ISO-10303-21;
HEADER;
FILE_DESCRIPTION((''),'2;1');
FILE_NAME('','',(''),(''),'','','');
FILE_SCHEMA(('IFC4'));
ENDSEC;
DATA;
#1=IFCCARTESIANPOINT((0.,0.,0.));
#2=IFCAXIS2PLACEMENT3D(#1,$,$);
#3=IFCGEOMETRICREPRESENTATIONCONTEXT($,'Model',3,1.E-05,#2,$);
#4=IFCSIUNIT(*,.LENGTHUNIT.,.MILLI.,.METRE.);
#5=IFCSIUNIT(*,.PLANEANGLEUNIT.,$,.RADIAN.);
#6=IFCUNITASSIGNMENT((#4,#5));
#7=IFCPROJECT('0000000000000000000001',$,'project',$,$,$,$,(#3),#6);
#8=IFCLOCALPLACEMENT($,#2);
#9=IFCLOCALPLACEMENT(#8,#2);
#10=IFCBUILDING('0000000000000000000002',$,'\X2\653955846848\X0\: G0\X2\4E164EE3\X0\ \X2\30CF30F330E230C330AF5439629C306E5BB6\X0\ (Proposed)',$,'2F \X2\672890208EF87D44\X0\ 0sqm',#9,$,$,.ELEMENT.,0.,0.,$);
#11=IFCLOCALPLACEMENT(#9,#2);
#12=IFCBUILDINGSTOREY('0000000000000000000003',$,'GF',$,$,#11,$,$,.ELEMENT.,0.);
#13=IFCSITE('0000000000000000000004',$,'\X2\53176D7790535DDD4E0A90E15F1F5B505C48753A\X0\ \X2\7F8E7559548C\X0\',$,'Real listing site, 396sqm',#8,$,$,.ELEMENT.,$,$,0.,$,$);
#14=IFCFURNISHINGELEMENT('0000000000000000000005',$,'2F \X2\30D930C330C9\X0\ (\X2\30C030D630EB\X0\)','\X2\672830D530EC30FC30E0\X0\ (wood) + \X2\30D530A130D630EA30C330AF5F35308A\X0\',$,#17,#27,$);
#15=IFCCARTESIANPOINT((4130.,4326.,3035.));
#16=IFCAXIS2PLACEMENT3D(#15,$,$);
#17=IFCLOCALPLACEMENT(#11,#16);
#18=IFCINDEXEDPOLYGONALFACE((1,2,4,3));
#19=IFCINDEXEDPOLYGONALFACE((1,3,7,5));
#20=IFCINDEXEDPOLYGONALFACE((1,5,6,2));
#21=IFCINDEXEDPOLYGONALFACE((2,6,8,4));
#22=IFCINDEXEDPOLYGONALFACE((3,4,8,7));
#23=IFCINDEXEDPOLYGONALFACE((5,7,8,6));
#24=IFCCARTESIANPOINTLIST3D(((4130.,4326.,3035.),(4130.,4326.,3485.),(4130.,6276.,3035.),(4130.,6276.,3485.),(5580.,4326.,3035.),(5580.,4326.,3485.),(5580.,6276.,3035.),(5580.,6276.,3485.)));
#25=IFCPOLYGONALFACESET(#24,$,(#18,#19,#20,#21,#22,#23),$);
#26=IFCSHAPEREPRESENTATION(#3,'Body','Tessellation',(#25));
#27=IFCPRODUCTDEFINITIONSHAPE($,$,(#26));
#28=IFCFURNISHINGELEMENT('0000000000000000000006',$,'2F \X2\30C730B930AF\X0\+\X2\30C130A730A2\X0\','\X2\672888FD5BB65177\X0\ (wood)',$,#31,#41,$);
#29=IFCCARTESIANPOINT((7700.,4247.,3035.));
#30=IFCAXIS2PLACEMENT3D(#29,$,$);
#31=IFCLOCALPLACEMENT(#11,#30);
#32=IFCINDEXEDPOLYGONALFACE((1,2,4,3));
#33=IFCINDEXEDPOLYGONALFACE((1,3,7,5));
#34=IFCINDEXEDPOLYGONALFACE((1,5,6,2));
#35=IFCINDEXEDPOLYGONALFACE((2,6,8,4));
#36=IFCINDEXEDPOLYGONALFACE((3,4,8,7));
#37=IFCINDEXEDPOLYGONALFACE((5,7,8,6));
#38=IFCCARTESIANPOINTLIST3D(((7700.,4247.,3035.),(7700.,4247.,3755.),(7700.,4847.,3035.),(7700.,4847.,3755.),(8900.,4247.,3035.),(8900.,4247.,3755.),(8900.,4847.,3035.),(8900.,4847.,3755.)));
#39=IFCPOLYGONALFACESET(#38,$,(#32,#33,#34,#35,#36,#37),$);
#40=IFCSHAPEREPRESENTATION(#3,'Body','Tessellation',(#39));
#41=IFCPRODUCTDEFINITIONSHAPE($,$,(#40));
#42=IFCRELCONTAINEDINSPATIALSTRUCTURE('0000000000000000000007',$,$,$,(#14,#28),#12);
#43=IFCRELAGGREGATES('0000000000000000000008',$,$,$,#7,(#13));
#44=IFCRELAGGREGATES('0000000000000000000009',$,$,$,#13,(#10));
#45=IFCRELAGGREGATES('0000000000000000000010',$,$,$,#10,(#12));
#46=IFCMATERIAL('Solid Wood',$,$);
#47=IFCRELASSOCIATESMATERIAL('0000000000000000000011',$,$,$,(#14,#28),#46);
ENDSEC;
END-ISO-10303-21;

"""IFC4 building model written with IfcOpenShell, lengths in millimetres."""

from ifc_helpers import new_model, si_unit, frame, frame_2d, origin, place, context, project, spatial, rectangle, extrude, material, element, save


model = new_model("IFC4")

# Units and contexts
model_context = context("Model", 3, precision=1e-05, world=origin())
ifc_project = project(units=[si_unit("LENGTHUNIT", "METRE", prefix="MILLI"), si_unit("PLANEANGLEUNIT", "RADIAN")], contexts=[model_context])

# Site, building, storey
site_placement = place(None, origin())
site = spatial("IfcSite", under=ifc_project, at=site_placement, Name="北海道川上郡弟子屈町 美留和", ObjectType="Real listing site, 396sqm", CompositionType="ELEMENT", RefElevation=0.0)
building_placement = place(site_placement, origin())
building = spatial("IfcBuilding", under=site, at=building_placement, Name="改善案: G0世代 ハンモック吹抜の家 (Proposed)", ObjectType="2F 木造軸組 0sqm", CompositionType="ELEMENT", ElevationOfRefHeight=0.0, ElevationOfTerrain=0.0)
storey_placement = place(building_placement, origin())
storey = spatial("IfcBuildingStorey", under=building, at=storey_placement, Name="GF", CompositionType="ELEMENT", Elevation=0.0)

# Shared definitions
ifc_material_1 = material(Name="Solid Wood")

# Furnishing elements
furnishing_1_placement = place(storey_placement, frame((4130.0, 4326.0, 3035.0)))
element("IfcFurnishingElement", 1, at=furnishing_1_placement, inside=storey, material=ifc_material_1, Name="2F ベッド (ダブル)", Description="木フレーム (wood) + ファブリック張り", context=model_context, shape_type="SweptSolid", body=[
    extrude(rectangle(XDim=1450.0, YDim=1950.0, at=frame_2d((725.0, 975.0))), frame((4130.0, 4326.0, 3035.0)), (0.0, 0.0, 1.0), 450.0),
])
furnishing_2_placement = place(storey_placement, frame((7700.0, 4247.0, 3035.0)))
element("IfcFurnishingElement", 2, at=furnishing_2_placement, inside=storey, material=ifc_material_1, Name="2F デスク+チェア", Description="木製家具 (wood)", context=model_context, shape_type="SweptSolid", body=[
    extrude(rectangle(XDim=1200.0, YDim=600.0, at=frame_2d((600.0, 300.0))), frame((7700.0, 4247.0, 3035.0)), (0.0, 0.0, 1.0), 720.0),
])

save(model, "model.ifc")
